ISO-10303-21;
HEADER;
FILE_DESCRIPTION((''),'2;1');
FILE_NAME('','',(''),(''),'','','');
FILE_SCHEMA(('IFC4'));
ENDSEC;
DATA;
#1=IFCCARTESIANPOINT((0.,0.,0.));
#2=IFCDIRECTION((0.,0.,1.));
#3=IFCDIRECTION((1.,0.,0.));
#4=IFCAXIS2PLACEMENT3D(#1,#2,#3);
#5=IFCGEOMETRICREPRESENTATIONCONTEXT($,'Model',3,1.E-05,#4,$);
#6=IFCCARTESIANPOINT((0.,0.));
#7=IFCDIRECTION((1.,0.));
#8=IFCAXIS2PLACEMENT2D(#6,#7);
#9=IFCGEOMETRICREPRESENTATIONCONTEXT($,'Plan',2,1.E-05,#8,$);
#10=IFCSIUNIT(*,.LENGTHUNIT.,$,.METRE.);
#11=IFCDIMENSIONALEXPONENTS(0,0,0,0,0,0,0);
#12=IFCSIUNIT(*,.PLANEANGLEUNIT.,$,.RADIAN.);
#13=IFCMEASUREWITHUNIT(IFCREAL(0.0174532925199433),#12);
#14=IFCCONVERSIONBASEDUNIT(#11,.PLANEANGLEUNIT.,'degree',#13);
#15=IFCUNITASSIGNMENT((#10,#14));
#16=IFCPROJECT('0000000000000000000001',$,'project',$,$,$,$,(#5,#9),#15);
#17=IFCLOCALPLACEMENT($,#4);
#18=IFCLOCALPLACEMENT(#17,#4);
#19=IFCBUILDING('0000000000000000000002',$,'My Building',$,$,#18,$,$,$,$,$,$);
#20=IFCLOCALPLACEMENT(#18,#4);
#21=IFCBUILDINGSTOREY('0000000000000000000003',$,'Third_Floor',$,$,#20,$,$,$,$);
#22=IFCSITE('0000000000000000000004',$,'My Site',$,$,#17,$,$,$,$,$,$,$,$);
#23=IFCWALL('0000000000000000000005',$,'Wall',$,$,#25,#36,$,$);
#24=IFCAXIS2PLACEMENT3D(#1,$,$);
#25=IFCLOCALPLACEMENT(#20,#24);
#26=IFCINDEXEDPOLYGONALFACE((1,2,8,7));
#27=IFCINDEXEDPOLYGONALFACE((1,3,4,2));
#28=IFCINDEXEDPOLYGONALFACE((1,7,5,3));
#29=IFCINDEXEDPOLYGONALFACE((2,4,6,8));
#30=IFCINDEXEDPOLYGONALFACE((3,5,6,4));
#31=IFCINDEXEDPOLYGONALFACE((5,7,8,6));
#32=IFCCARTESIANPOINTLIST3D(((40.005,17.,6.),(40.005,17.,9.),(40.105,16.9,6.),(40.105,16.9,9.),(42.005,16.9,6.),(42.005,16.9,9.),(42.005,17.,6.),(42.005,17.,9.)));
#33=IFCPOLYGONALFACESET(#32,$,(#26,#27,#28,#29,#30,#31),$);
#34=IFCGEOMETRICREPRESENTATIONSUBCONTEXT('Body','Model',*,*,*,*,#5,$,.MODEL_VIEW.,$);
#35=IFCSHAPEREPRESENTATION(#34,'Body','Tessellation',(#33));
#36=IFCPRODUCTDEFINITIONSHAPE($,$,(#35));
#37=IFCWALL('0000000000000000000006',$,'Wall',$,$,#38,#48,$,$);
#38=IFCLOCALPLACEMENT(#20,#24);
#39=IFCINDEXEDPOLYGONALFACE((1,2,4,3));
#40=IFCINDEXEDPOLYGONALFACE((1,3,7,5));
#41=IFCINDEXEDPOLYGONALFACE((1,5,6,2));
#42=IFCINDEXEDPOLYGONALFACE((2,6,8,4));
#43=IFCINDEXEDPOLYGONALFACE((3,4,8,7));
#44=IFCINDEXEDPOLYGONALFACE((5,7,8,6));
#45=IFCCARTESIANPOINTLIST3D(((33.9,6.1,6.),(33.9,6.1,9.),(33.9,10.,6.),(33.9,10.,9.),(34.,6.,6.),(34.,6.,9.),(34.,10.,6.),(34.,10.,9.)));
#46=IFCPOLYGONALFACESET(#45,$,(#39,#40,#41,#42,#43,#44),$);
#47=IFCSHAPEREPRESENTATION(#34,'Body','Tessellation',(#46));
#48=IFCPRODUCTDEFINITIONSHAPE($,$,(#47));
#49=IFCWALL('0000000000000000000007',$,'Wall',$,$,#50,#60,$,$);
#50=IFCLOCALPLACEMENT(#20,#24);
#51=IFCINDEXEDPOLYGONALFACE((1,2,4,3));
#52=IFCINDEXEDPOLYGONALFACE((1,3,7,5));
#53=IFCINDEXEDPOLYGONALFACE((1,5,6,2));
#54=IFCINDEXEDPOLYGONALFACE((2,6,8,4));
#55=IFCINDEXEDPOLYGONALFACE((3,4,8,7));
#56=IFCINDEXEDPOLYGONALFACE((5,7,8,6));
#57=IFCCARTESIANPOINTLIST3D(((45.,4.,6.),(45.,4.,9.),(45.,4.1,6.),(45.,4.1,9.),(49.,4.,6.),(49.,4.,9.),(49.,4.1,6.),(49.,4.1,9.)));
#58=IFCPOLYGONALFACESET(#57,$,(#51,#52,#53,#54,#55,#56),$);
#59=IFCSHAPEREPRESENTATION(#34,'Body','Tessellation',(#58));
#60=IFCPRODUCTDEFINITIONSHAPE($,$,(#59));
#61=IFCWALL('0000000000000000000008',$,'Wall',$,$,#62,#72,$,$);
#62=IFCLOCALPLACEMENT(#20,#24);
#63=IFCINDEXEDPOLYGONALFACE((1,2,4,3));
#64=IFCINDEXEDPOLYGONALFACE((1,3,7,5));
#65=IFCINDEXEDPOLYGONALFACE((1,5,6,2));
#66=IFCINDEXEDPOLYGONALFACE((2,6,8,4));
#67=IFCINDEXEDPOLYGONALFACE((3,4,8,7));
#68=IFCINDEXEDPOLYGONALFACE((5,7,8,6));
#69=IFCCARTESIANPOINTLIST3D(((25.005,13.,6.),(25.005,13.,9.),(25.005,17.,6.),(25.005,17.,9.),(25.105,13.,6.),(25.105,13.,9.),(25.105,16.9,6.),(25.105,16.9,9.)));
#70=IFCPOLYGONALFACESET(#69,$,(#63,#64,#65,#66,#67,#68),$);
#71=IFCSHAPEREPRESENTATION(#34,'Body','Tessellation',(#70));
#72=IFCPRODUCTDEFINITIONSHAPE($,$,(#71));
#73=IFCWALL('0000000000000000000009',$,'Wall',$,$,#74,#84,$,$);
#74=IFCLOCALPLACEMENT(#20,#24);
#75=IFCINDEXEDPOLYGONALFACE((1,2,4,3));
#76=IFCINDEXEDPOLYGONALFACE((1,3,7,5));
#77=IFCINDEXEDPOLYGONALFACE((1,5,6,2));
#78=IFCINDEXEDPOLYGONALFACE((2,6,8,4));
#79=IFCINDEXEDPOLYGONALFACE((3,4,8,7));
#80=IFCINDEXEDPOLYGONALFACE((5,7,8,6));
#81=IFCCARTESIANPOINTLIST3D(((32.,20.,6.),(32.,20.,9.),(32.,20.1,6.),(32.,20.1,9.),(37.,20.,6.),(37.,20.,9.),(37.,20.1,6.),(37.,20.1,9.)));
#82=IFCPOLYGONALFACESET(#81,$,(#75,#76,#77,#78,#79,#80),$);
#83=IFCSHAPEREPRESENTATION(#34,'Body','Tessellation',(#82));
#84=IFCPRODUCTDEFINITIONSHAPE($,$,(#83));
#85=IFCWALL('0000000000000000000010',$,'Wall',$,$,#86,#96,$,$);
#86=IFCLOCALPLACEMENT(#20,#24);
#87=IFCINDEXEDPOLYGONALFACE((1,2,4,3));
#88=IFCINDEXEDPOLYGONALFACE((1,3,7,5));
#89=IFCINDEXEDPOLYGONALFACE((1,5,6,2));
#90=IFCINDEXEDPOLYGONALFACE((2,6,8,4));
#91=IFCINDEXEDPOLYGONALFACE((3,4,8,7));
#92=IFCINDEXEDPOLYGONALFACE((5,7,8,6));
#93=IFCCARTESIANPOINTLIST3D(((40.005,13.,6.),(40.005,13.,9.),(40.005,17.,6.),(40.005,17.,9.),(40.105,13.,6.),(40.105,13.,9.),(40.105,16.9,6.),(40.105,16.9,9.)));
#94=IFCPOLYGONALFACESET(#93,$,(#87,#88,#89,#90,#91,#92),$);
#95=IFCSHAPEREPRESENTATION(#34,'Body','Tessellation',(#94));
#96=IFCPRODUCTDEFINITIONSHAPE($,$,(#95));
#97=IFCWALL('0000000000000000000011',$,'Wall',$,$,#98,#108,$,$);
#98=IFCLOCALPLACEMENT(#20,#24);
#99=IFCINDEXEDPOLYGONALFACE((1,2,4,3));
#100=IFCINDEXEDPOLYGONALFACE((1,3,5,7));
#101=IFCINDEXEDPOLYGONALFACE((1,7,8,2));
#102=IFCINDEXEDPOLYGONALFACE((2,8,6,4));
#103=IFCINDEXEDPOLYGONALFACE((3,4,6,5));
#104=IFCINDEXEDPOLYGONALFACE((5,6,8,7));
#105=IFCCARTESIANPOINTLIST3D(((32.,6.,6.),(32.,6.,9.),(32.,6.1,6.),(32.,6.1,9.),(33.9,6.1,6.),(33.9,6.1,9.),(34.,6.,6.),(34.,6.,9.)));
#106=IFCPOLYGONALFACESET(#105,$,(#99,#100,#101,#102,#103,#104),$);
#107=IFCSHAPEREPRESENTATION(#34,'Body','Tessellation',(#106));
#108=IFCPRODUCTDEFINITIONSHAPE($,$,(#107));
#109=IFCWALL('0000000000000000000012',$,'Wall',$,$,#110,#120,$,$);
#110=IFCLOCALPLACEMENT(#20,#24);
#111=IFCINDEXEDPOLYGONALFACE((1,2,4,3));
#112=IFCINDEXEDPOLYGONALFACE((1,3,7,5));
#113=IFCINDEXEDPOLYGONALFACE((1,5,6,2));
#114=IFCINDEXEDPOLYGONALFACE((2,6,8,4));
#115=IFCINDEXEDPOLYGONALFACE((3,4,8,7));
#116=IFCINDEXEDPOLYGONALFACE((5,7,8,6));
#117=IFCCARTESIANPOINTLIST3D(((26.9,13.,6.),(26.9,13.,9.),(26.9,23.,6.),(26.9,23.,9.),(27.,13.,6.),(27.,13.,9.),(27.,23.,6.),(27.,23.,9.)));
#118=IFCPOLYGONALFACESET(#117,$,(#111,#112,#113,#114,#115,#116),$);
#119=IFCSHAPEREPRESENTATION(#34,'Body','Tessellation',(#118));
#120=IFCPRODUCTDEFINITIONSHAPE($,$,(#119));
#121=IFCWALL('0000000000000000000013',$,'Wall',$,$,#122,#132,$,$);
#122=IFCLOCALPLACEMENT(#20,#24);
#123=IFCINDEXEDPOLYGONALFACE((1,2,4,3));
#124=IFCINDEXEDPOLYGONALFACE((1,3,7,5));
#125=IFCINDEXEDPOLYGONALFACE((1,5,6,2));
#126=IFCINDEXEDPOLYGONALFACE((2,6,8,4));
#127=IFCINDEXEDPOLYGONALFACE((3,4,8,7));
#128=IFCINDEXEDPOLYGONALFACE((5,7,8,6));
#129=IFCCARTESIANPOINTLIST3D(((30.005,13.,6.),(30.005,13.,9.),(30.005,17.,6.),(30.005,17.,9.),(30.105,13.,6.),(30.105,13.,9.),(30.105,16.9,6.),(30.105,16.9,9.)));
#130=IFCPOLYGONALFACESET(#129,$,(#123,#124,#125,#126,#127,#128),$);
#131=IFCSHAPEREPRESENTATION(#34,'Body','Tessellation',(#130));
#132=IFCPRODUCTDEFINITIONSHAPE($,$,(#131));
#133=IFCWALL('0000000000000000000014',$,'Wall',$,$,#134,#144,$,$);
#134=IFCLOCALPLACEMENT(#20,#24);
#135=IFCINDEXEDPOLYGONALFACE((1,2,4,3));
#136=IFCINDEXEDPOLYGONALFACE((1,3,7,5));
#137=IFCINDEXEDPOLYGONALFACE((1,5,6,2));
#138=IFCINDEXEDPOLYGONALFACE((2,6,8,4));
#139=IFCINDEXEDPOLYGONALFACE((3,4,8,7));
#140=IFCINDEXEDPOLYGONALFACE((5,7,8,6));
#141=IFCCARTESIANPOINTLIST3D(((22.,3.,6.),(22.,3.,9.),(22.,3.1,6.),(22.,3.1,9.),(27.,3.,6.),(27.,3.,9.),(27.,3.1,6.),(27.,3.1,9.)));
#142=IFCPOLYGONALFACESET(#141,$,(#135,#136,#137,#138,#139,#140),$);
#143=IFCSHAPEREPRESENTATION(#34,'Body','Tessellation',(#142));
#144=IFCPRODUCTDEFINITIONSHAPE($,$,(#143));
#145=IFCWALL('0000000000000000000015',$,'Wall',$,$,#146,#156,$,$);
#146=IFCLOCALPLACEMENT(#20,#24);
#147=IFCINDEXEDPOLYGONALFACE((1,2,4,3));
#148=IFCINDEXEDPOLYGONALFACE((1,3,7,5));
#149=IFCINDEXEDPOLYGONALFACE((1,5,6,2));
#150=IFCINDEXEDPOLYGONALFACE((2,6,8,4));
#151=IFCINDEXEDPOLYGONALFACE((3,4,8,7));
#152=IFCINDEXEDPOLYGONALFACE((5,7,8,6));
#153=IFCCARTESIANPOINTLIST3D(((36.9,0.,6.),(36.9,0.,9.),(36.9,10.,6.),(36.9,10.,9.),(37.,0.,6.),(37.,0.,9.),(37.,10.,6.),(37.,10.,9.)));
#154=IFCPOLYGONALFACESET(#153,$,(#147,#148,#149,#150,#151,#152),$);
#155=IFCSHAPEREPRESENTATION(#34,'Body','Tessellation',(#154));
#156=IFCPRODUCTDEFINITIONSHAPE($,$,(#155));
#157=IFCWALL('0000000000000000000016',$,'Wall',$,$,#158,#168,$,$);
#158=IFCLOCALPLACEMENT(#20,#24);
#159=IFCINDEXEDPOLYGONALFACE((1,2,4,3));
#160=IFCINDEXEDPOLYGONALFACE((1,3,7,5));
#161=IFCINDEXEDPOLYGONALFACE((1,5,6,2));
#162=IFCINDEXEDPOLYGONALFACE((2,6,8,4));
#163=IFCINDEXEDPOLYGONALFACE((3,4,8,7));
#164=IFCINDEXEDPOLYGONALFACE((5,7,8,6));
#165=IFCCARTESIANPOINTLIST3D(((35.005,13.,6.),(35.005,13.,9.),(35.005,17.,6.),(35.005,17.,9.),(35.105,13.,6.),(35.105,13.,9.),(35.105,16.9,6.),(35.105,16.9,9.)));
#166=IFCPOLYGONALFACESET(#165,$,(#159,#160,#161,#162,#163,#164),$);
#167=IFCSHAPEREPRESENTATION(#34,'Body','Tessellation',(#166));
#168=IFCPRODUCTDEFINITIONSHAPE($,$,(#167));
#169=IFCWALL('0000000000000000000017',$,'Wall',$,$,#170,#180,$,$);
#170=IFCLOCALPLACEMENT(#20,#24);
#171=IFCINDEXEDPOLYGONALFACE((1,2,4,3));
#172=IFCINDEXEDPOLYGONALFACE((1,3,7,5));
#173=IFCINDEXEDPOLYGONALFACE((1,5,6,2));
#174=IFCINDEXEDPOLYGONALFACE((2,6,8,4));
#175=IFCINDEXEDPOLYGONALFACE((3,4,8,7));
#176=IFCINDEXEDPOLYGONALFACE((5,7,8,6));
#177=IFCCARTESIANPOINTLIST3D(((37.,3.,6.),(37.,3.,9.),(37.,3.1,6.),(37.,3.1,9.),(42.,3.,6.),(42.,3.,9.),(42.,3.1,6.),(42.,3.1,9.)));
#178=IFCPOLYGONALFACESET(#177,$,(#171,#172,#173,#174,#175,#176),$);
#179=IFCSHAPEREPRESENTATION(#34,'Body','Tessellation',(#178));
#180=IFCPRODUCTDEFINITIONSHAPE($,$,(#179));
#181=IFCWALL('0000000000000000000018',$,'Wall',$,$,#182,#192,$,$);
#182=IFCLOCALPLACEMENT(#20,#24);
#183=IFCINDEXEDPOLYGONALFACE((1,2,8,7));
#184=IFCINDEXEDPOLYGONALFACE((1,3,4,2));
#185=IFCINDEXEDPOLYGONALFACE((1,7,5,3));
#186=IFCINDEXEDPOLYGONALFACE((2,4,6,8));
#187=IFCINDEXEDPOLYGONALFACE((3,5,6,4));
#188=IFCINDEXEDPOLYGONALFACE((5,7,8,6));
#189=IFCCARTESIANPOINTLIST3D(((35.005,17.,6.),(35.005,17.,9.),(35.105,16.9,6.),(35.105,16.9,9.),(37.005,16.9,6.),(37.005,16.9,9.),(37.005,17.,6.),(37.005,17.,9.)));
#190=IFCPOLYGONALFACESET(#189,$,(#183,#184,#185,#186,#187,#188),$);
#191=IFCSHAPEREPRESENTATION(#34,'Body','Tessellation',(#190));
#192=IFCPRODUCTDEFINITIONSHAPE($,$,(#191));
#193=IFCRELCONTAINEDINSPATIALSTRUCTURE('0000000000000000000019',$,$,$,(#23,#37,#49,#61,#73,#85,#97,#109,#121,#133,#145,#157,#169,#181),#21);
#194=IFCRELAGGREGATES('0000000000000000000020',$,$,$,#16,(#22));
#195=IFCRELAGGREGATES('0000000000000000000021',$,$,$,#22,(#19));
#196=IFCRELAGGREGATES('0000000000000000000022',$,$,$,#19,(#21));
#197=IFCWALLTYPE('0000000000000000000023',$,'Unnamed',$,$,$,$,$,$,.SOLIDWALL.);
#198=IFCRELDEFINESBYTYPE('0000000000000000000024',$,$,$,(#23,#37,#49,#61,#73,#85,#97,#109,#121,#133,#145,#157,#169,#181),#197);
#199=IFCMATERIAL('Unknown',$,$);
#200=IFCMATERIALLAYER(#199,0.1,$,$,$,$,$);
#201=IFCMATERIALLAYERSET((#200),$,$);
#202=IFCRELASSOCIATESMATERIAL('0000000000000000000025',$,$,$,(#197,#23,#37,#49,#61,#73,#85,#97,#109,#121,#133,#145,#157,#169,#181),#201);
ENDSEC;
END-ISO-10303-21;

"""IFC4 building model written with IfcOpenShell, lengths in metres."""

from ifc_helpers import new_model, entity, si_unit, converted_unit, frame, origin_with_axes, origin_2d_with_axis, place, context, subcontext, project, spatial, line, indexed_curve, outline, extrude, material, layer, layer_set, layer_usage, type_object, element, save


model = new_model("IFC4")

# Units and contexts
model_context = context("Model", 3, precision=1e-05, world=origin_with_axes())
plan_context = context("Plan", 2, precision=1e-05, world=origin_2d_with_axis())
body_context = subcontext(model_context, "Body", "Model", "MODEL_VIEW")
ifc_project = project(units=[si_unit("LENGTHUNIT", "METRE"), converted_unit("PLANEANGLEUNIT", "degree", entity("IfcReal", 0.0174532925199433), si_unit("PLANEANGLEUNIT", "RADIAN"), dimensions=[0, 0, 0, 0, 0, 0, 0])], contexts=[model_context, plan_context])

# Site, building, storey
site_placement = place(None, origin_with_axes())
site = spatial("IfcSite", under=ifc_project, at=site_placement, Name="My Site")
building_placement = place(site_placement, origin_with_axes())
building = spatial("IfcBuilding", under=site, at=building_placement, Name="My Building")
storey_placement = place(building_placement, origin_with_axes())
storey = spatial("IfcBuildingStorey", under=building, at=storey_placement, Name="Third_Floor")

# Walls
ifc_material = material(Name="Unknown")
ifc_layer = layer(ifc_material, 0.1)
ifc_layer_set = layer_set([ifc_layer])
wall_type = type_object("IfcWallType", Name="Unnamed", PredefinedType="SOLIDWALL", material=ifc_layer_set)
ifc_layer_usage_1 = layer_usage(ifc_layer_set, "AXIS2", "POSITIVE", 0.0)
wall_1_placement = place(storey_placement, frame((42.005, 17.0, 6.0), z_axis=(0.0, 0.0, 1.0), x_axis=(-1.0, 0.0, 0.0)))
element("IfcWall", 1, at=wall_1_placement, inside=storey, type_object=wall_type, material=ifc_layer_usage_1, Name="Wall", context=body_context, shape_type="SweptSolid", body=[
    extrude(outline(indexed_curve([(0.0, 0.0), (0.0, 0.1), (1.9, 0.1), (2.0, 0.0)], segments=[line(1, 2, 3, 4, 1)])), origin_with_axes(), (0.0, 0.0, 1.0), 3.0),
])
ifc_layer_usage_2 = layer_usage(ifc_layer_set, "AXIS2", "POSITIVE", 0.0)
wall_2_placement = place(storey_placement, frame((34.0, 6.0, 6.0), z_axis=(0.0, 0.0, 1.0), x_axis=(0.0, 1.0, 0.0)))
element("IfcWall", 2, at=wall_2_placement, inside=storey, type_object=wall_type, material=ifc_layer_usage_2, Name="Wall", context=body_context, shape_type="SweptSolid", body=[
    extrude(outline(indexed_curve([(0.0, 0.0), (0.1, 0.1), (4.0, 0.1), (4.0, 0.0)], segments=[line(1, 2, 3, 4, 1)])), origin_with_axes(), (0.0, 0.0, 1.0), 3.0),
])
ifc_layer_usage_3 = layer_usage(ifc_layer_set, "AXIS2", "POSITIVE", 0.0)
wall_3_placement = place(storey_placement, frame((45.0, 4.0, 6.0), z_axis=(0.0, 0.0, 1.0), x_axis=(1.0, 0.0, 0.0)))
element("IfcWall", 3, at=wall_3_placement, inside=storey, type_object=wall_type, material=ifc_layer_usage_3, Name="Wall", context=body_context, shape_type="SweptSolid", body=[
    extrude(outline(indexed_curve([(0.0, 0.0), (0.0, 0.1), (4.0, 0.1), (4.0, 0.0)], segments=[line(1, 2, 3, 4, 1)])), origin_with_axes(), (0.0, 0.0, 1.0), 3.0),
])
ifc_layer_usage_4 = layer_usage(ifc_layer_set, "AXIS2", "POSITIVE", 0.0)
wall_4_placement = place(storey_placement, frame((25.005, 17.0, 6.0), z_axis=(0.0, 0.0, 1.0), x_axis=(0.0, -1.0, 0.0)))
element("IfcWall", 4, at=wall_4_placement, inside=storey, type_object=wall_type, material=ifc_layer_usage_4, Name="Wall", context=body_context, shape_type="SweptSolid", body=[
    extrude(outline(indexed_curve([(0.0, 0.0), (0.1, 0.1), (4.0, 0.1), (4.0, 0.0)], segments=[line(1, 2, 3, 4, 1)])), origin_with_axes(), (0.0, 0.0, 1.0), 3.0),
])
ifc_layer_usage_5 = layer_usage(ifc_layer_set, "AXIS2", "POSITIVE", 0.0)
wall_5_placement = place(storey_placement, frame((32.0, 20.0, 6.0), z_axis=(0.0, 0.0, 1.0), x_axis=(1.0, 0.0, 0.0)))
element("IfcWall", 5, at=wall_5_placement, inside=storey, type_object=wall_type, material=ifc_layer_usage_5, Name="Wall", context=body_context, shape_type="SweptSolid", body=[
    extrude(outline(indexed_curve([(0.0, 0.0), (0.0, 0.1), (5.0, 0.1), (5.0, 0.0)], segments=[line(1, 2, 3, 4, 1)])), origin_with_axes(), (0.0, 0.0, 1.0), 3.0),
])
ifc_layer_usage_6 = layer_usage(ifc_layer_set, "AXIS2", "POSITIVE", 0.0)
wall_6_placement = place(storey_placement, frame((40.005, 17.0, 6.0), z_axis=(0.0, 0.0, 1.0), x_axis=(0.0, -1.0, 0.0)))
element("IfcWall", 6, at=wall_6_placement, inside=storey, type_object=wall_type, material=ifc_layer_usage_6, Name="Wall", context=body_context, shape_type="SweptSolid", body=[
    extrude(outline(indexed_curve([(0.0, 0.0), (0.1, 0.1), (4.0, 0.1), (4.0, 0.0)], segments=[line(1, 2, 3, 4, 1)])), origin_with_axes(), (0.0, 0.0, 1.0), 3.0),
])
ifc_layer_usage_7 = layer_usage(ifc_layer_set, "AXIS2", "POSITIVE", 0.0)
wall_7_placement = place(storey_placement, frame((32.0, 6.0, 6.0), z_axis=(0.0, 0.0, 1.0), x_axis=(1.0, 0.0, 0.0)))
element("IfcWall", 7, at=wall_7_placement, inside=storey, type_object=wall_type, material=ifc_layer_usage_7, Name="Wall", context=body_context, shape_type="SweptSolid", body=[
    extrude(outline(indexed_curve([(0.0, 0.0), (0.0, 0.1), (1.9, 0.1), (2.0, 0.0)], segments=[line(1, 2, 3, 4, 1)])), origin_with_axes(), (0.0, 0.0, 1.0), 3.0),
])
ifc_layer_usage_8 = layer_usage(ifc_layer_set, "AXIS2", "POSITIVE", 0.0)
wall_8_placement = place(storey_placement, frame((26.9, 23.0, 6.0), z_axis=(0.0, 0.0, 1.0), x_axis=(0.0, -1.0, 0.0)))
element("IfcWall", 8, at=wall_8_placement, inside=storey, type_object=wall_type, material=ifc_layer_usage_8, Name="Wall", context=body_context, shape_type="SweptSolid", body=[
    extrude(outline(indexed_curve([(0.0, 0.0), (0.0, 0.1), (10.0, 0.1), (10.0, 0.0)], segments=[line(1, 2, 3, 4, 1)])), origin_with_axes(), (0.0, 0.0, 1.0), 3.0),
])
ifc_layer_usage_9 = layer_usage(ifc_layer_set, "AXIS2", "POSITIVE", 0.0)
wall_9_placement = place(storey_placement, frame((30.005, 17.0, 6.0), z_axis=(0.0, 0.0, 1.0), x_axis=(0.0, -1.0, 0.0)))
element("IfcWall", 9, at=wall_9_placement, inside=storey, type_object=wall_type, material=ifc_layer_usage_9, Name="Wall", context=body_context, shape_type="SweptSolid", body=[
    extrude(outline(indexed_curve([(0.0, 0.0), (0.1, 0.1), (4.0, 0.1), (4.0, 0.0)], segments=[line(1, 2, 3, 4, 1)])), origin_with_axes(), (0.0, 0.0, 1.0), 3.0),
])
ifc_layer_usage_10 = layer_usage(ifc_layer_set, "AXIS2", "POSITIVE", 0.0)
wall_10_placement = place(storey_placement, frame((22.0, 3.0, 6.0), z_axis=(0.0, 0.0, 1.0), x_axis=(1.0, 0.0, 0.0)))
element("IfcWall", 10, at=wall_10_placement, inside=storey, type_object=wall_type, material=ifc_layer_usage_10, Name="Wall", context=body_context, shape_type="SweptSolid", body=[
    extrude(outline(indexed_curve([(0.0, 0.0), (0.0, 0.1), (5.0, 0.1), (5.0, 0.0)], segments=[line(1, 2, 3, 4, 1)])), origin_with_axes(), (0.0, 0.0, 1.0), 3.0),
])
ifc_layer_usage_11 = layer_usage(ifc_layer_set, "AXIS2", "POSITIVE", 0.0)
wall_11_placement = place(storey_placement, frame((36.9, 10.0, 6.0), z_axis=(0.0, 0.0, 1.0), x_axis=(0.0, -1.0, 0.0)))
element("IfcWall", 11, at=wall_11_placement, inside=storey, type_object=wall_type, material=ifc_layer_usage_11, Name="Wall", context=body_context, shape_type="SweptSolid", body=[
    extrude(outline(indexed_curve([(0.0, 0.0), (0.0, 0.1), (10.0, 0.1), (10.0, 0.0)], segments=[line(1, 2, 3, 4, 1)])), origin_with_axes(), (0.0, 0.0, 1.0), 3.0),
])
ifc_layer_usage_12 = layer_usage(ifc_layer_set, "AXIS2", "POSITIVE", 0.0)
wall_12_placement = place(storey_placement, frame((35.005, 17.0, 6.0), z_axis=(0.0, 0.0, 1.0), x_axis=(0.0, -1.0, 0.0)))
element("IfcWall", 12, at=wall_12_placement, inside=storey, type_object=wall_type, material=ifc_layer_usage_12, Name="Wall", context=body_context, shape_type="SweptSolid", body=[
    extrude(outline(indexed_curve([(0.0, 0.0), (0.1, 0.1), (4.0, 0.1), (4.0, 0.0)], segments=[line(1, 2, 3, 4, 1)])), origin_with_axes(), (0.0, 0.0, 1.0), 3.0),
])
ifc_layer_usage_13 = layer_usage(ifc_layer_set, "AXIS2", "POSITIVE", 0.0)
wall_13_placement = place(storey_placement, frame((37.0, 3.0, 6.0), z_axis=(0.0, 0.0, 1.0), x_axis=(1.0, 0.0, 0.0)))
element("IfcWall", 13, at=wall_13_placement, inside=storey, type_object=wall_type, material=ifc_layer_usage_13, Name="Wall", context=body_context, shape_type="SweptSolid", body=[
    extrude(outline(indexed_curve([(0.0, 0.0), (0.0, 0.1), (5.0, 0.1), (5.0, 0.0)], segments=[line(1, 2, 3, 4, 1)])), origin_with_axes(), (0.0, 0.0, 1.0), 3.0),
])
ifc_layer_usage_14 = layer_usage(ifc_layer_set, "AXIS2", "POSITIVE", 0.0)
wall_14_placement = place(storey_placement, frame((37.005, 17.0, 6.0), z_axis=(0.0, 0.0, 1.0), x_axis=(-1.0, 0.0, 0.0)))
element("IfcWall", 14, at=wall_14_placement, inside=storey, type_object=wall_type, material=ifc_layer_usage_14, Name="Wall", context=body_context, shape_type="SweptSolid", body=[
    extrude(outline(indexed_curve([(0.0, 0.0), (0.0, 0.1), (1.9, 0.1), (2.0, 0.0)], segments=[line(1, 2, 3, 4, 1)])), origin_with_axes(), (0.0, 0.0, 1.0), 3.0),
])

save(model, "model.ifc")
